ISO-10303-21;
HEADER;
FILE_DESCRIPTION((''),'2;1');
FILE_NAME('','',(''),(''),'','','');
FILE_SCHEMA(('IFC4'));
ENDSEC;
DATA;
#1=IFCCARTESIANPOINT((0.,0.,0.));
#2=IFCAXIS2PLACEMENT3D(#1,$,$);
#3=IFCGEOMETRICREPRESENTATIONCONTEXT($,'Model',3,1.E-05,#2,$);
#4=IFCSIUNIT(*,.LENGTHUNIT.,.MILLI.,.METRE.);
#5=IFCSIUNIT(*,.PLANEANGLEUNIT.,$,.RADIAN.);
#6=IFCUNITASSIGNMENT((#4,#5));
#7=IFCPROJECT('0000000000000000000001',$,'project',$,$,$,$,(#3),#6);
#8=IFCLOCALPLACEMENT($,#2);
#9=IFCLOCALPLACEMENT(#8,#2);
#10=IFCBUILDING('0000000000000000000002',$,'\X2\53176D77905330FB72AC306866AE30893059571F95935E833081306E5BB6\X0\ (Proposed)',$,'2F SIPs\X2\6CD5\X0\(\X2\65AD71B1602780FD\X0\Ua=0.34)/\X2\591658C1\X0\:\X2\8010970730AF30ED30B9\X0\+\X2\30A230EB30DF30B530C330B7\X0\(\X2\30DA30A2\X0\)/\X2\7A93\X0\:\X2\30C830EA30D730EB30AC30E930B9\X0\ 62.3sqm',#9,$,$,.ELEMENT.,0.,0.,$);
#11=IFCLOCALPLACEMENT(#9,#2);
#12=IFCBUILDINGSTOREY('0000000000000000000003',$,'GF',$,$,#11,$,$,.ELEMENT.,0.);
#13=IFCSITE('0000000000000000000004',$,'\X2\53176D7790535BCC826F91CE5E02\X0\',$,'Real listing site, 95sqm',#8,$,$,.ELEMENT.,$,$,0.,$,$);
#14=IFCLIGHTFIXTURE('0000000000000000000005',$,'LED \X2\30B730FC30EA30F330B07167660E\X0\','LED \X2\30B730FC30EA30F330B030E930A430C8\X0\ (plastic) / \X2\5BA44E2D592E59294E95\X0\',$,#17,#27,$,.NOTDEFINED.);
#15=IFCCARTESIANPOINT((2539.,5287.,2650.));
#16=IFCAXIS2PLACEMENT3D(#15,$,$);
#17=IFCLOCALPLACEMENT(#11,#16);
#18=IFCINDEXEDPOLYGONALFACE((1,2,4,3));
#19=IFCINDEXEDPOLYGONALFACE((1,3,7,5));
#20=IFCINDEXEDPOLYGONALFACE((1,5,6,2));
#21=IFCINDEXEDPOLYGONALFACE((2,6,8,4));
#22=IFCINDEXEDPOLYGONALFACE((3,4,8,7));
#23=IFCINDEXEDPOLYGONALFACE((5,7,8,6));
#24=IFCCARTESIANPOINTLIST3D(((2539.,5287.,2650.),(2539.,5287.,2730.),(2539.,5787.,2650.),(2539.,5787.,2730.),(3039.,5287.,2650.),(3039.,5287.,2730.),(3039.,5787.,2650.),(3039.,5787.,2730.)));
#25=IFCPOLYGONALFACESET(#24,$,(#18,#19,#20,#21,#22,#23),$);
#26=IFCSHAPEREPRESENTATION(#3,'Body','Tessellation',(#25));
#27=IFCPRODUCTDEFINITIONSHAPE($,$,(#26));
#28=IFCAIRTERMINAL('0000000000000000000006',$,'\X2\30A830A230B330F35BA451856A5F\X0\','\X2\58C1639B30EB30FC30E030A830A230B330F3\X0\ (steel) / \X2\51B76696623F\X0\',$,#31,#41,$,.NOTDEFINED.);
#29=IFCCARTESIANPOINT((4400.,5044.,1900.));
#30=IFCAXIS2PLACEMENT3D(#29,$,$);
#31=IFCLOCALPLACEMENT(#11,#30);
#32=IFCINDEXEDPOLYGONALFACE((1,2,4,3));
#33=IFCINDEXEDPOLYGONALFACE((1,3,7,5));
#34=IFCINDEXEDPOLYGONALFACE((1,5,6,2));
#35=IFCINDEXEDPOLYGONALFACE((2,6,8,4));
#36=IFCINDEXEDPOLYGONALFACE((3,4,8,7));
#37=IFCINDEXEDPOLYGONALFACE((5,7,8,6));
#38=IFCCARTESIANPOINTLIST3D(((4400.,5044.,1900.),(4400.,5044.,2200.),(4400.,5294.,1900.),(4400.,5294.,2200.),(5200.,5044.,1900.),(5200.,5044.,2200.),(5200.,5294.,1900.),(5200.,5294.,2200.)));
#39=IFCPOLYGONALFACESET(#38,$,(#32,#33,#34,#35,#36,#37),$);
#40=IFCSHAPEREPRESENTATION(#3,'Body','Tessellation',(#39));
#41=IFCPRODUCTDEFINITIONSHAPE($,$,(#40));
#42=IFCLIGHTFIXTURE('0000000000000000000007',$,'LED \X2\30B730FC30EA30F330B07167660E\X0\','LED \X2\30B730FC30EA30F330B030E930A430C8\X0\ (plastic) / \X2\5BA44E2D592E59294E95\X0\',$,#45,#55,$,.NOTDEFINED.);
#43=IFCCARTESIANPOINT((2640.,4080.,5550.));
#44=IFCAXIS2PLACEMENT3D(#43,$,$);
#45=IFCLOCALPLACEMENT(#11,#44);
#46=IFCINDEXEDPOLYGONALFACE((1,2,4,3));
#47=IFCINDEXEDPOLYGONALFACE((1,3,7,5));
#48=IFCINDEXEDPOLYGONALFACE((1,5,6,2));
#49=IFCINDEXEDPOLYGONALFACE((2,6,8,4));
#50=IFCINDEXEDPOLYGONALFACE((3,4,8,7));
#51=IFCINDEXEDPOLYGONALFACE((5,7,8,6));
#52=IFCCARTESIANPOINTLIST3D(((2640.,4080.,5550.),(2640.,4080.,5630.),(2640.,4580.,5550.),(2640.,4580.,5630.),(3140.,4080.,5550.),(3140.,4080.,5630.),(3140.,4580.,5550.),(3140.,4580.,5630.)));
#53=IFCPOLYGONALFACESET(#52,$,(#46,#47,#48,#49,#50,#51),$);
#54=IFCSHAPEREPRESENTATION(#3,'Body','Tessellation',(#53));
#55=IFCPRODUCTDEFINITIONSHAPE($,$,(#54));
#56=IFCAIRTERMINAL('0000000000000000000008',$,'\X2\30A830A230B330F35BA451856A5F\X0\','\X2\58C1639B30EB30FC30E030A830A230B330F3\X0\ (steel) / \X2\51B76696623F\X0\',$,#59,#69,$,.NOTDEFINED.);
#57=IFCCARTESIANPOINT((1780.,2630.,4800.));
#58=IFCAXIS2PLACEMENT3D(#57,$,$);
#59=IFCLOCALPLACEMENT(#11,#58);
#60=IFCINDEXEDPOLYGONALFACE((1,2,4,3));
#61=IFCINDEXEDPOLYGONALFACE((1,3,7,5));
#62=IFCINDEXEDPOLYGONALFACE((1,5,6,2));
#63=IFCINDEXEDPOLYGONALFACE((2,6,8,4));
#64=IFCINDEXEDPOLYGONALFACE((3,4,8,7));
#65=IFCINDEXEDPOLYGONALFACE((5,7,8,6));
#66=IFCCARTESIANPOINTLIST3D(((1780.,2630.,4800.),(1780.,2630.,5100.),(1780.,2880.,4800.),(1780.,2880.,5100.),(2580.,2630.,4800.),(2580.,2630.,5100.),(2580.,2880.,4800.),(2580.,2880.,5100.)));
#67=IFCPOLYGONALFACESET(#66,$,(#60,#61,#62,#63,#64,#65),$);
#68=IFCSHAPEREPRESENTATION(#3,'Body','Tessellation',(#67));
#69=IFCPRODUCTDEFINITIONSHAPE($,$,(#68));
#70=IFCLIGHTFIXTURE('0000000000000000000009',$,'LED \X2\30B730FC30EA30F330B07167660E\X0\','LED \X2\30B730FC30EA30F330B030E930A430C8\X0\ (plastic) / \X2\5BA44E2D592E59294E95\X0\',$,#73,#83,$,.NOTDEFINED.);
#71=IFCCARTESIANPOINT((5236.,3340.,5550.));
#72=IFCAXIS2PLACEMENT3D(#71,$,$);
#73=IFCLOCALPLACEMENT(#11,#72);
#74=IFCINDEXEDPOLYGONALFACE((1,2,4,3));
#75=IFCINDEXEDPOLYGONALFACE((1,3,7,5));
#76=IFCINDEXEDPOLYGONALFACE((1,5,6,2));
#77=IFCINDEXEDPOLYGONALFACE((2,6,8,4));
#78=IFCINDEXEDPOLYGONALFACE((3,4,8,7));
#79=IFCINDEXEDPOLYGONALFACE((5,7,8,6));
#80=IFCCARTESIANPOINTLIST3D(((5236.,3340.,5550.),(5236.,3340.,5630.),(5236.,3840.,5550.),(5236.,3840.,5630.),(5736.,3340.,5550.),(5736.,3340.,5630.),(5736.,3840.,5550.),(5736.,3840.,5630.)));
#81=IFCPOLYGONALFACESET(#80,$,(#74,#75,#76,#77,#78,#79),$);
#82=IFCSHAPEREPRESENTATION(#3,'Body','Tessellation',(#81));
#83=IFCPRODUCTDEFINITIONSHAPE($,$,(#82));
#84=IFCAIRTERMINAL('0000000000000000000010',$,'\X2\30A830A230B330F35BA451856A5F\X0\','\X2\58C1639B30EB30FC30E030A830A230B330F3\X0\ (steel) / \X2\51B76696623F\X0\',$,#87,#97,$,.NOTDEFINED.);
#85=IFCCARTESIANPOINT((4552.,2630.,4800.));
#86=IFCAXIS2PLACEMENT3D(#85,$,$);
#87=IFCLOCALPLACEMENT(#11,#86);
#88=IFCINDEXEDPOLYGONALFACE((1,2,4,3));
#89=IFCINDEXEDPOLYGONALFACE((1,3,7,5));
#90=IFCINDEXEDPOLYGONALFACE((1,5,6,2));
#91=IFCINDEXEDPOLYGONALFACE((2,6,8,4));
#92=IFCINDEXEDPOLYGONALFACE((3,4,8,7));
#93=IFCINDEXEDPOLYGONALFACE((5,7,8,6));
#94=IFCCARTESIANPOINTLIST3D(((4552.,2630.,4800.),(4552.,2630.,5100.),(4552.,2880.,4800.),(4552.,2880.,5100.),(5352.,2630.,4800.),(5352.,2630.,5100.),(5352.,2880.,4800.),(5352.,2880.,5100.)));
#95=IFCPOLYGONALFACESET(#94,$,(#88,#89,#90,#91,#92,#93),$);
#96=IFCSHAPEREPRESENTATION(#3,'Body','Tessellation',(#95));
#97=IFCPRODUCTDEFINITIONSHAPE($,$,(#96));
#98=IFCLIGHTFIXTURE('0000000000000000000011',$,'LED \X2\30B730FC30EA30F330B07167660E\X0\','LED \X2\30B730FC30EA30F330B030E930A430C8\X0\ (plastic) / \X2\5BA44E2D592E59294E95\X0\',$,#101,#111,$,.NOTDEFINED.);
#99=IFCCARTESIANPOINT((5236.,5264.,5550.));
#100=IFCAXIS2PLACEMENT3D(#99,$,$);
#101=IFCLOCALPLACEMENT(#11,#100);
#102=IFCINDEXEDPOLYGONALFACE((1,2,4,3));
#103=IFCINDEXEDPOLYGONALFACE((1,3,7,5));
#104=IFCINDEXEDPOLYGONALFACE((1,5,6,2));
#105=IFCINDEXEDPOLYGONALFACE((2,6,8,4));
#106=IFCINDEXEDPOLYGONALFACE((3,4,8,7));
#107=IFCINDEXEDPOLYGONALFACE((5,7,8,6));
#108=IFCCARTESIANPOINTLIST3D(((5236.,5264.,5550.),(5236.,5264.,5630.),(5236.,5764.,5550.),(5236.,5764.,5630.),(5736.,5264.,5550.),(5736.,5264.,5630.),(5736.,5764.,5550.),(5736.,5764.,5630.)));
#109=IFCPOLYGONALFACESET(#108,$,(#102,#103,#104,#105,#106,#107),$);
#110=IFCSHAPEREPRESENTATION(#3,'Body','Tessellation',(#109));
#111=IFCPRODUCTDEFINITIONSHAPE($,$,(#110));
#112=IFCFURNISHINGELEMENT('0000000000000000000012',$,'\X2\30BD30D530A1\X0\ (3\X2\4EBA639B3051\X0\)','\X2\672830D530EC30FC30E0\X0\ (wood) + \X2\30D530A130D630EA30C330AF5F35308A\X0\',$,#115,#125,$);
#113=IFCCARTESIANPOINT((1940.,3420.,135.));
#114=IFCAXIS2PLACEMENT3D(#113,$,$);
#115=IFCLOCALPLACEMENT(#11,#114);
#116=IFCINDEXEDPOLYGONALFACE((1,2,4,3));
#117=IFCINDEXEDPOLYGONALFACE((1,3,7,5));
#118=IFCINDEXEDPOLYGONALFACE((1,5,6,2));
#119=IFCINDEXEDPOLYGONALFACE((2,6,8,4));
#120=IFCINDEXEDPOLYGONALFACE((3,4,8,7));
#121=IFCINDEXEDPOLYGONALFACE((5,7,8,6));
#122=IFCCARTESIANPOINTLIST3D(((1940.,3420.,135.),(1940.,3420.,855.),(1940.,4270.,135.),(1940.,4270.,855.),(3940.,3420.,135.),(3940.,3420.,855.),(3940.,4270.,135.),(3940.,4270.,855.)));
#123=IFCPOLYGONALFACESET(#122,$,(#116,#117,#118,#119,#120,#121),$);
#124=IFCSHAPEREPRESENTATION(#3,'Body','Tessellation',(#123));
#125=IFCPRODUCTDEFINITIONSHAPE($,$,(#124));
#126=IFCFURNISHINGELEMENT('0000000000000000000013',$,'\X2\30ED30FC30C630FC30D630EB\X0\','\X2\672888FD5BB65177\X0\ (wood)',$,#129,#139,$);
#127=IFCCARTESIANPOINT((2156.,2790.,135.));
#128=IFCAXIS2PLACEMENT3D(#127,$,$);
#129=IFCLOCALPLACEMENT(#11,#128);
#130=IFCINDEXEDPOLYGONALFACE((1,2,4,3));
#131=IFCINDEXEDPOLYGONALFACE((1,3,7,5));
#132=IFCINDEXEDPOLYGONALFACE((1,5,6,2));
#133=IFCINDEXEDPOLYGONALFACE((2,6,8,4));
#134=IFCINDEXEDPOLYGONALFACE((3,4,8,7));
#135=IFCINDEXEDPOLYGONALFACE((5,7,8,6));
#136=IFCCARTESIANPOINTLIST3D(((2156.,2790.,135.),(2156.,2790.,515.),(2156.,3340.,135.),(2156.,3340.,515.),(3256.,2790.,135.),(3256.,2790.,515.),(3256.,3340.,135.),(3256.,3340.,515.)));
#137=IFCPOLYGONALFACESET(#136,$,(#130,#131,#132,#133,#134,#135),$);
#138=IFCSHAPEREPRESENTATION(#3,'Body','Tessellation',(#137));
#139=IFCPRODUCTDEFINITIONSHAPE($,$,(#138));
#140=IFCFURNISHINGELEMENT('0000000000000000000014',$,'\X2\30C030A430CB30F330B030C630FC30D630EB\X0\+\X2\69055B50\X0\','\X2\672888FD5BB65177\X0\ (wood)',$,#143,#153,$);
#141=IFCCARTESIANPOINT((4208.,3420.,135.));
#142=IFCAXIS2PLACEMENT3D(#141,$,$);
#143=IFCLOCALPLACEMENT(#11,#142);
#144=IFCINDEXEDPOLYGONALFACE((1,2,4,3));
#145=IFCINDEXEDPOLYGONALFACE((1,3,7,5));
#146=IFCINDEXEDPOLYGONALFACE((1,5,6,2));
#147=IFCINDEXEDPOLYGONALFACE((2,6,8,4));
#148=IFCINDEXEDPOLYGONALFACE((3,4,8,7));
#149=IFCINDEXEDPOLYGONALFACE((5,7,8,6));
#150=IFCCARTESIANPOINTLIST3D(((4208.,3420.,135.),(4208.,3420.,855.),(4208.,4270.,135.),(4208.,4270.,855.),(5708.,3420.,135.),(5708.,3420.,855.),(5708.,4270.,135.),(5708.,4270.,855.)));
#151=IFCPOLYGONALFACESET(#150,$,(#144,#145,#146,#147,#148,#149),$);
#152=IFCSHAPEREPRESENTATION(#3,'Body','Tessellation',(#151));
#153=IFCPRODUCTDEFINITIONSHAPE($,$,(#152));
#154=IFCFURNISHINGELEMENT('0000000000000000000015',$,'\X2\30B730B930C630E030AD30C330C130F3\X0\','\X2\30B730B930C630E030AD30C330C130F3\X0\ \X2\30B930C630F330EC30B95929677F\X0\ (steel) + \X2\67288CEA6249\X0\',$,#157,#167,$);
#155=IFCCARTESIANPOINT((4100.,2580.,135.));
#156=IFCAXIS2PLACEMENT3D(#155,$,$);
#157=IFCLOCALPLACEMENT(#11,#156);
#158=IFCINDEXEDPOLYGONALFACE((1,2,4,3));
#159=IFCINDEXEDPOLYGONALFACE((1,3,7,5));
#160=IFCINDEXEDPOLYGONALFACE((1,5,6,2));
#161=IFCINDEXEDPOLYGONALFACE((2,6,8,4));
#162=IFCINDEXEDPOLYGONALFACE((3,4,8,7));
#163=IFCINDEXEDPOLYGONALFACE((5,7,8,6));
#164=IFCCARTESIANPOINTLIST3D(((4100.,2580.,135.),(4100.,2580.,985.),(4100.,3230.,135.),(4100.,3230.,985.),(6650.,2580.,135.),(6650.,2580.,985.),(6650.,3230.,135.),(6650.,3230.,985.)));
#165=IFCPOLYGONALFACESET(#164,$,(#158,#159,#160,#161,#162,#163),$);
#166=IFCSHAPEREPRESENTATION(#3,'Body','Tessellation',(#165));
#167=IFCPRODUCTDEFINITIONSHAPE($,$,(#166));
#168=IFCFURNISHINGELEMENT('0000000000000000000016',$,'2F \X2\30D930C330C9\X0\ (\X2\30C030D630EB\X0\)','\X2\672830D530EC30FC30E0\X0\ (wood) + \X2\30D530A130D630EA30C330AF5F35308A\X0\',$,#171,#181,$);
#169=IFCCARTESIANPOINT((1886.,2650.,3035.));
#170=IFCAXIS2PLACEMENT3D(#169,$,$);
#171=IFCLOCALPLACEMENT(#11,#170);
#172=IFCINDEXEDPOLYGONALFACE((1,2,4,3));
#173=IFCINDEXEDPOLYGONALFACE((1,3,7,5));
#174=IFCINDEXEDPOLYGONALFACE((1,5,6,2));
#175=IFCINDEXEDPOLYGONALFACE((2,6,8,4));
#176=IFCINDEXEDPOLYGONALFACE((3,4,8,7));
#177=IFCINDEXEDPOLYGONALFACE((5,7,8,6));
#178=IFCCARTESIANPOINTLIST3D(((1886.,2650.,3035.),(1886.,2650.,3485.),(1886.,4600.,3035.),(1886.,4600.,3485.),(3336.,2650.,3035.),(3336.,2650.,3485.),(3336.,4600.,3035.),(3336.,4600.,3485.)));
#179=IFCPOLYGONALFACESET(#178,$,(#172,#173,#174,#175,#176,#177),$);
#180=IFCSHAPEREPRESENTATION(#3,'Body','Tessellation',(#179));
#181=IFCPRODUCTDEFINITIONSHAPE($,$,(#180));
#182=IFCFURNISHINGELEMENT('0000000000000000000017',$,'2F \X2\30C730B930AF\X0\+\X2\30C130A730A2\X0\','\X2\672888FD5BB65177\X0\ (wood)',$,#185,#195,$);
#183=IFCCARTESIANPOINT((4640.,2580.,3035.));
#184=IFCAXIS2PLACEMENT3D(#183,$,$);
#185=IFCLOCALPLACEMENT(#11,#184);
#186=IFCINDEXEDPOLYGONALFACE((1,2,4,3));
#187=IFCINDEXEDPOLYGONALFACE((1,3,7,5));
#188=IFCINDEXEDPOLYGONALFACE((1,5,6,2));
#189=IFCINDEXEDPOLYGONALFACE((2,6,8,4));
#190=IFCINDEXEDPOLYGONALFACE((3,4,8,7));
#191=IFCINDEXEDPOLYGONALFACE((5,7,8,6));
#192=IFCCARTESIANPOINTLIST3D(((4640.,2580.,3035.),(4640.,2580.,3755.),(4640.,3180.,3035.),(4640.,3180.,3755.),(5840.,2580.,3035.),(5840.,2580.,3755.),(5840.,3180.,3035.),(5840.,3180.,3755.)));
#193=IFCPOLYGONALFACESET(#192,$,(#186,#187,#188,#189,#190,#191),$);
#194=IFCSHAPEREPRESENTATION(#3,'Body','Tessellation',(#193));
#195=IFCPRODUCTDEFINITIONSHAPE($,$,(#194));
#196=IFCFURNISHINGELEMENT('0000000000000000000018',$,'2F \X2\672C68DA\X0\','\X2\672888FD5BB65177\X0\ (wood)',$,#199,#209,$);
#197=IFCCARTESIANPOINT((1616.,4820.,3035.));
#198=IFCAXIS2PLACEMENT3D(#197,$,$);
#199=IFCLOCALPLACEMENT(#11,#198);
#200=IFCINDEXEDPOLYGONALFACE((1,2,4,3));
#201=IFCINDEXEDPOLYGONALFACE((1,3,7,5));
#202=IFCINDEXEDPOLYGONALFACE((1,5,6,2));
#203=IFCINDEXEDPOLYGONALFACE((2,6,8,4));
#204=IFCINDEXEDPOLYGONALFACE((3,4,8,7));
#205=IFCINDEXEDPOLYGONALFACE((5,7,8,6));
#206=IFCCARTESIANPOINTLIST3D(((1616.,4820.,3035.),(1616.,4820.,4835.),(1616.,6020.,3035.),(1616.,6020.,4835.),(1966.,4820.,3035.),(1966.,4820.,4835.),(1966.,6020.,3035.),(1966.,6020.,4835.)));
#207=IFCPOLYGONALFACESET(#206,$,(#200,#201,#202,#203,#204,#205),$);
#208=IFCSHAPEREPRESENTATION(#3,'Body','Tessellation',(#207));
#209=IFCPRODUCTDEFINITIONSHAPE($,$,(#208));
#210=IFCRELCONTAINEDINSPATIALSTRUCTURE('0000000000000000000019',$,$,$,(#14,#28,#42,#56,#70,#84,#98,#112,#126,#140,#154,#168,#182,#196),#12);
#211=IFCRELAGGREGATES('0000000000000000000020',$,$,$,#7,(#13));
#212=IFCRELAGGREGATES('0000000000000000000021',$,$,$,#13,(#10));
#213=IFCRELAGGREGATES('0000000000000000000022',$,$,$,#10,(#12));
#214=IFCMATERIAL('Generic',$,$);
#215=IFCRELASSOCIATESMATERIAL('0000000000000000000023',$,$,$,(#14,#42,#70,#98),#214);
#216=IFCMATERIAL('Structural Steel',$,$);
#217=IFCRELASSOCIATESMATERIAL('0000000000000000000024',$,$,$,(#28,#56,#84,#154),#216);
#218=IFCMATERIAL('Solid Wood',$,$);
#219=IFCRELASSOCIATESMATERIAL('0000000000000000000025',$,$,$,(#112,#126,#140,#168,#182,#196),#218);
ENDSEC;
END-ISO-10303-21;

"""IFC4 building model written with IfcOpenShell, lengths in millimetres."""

from ifc_helpers import new_model, si_unit, frame, frame_2d, origin, place, context, project, spatial, rectangle, extrude, material, element, save


model = new_model("IFC4")

# Units and contexts
model_context = context("Model", 3, precision=1e-05, world=origin())
ifc_project = project(units=[si_unit("LENGTHUNIT", "METRE", prefix="MILLI"), si_unit("PLANEANGLEUNIT", "RADIAN")], contexts=[model_context])

# Site, building, storey
site_placement = place(None, origin())
site = spatial("IfcSite", under=ifc_project, at=site_placement, Name="北海道富良野市", ObjectType="Real listing site, 95sqm", CompositionType="ELEMENT", RefElevation=0.0)
building_placement = place(site_placement, origin())
building = spatial("IfcBuilding", under=site, at=building_placement, Name="北海道・犬と暮らす土間広めの家 (Proposed)", ObjectType="2F SIPs法(断熱性能Ua=0.34)/外壁:耐震クロス+アルミサッシ(ペア)/窓:トリプルガラス 62.3sqm", CompositionType="ELEMENT", ElevationOfRefHeight=0.0, ElevationOfTerrain=0.0)
storey_placement = place(building_placement, origin())
storey = spatial("IfcBuildingStorey", under=building, at=storey_placement, Name="GF", CompositionType="ELEMENT", Elevation=0.0)

# Shared definitions
ifc_material_1 = material(Name="Solid Wood")

# Shared definitions
ifc_material_2 = material(Name="Structural Steel")

# Shared definitions
ifc_material_3 = material(Name="Generic")

# Light fixture
light_fixture_1_placement = place(storey_placement, frame((2539.0, 5287.0, 2650.0)))
element("IfcLightFixture", 1, at=light_fixture_1_placement, inside=storey, material=ifc_material_3, Name="LED シーリング照明", Description="LED シーリングライト (plastic) / 室中央天井", PredefinedType="NOTDEFINED", context=model_context, shape_type="SweptSolid", body=[
    extrude(rectangle(XDim=500.0, YDim=500.0, at=frame_2d((250.0, 250.0))), frame((2539.0, 5287.0, 2650.0)), (0.0, 0.0, 1.0), 80.0),
])

# Air terminal
air_terminal_1_placement = place(storey_placement, frame((4400.0, 5044.0, 1900.0)))
element("IfcAirTerminal", 2, at=air_terminal_1_placement, inside=storey, material=ifc_material_2, Name="エアコン室内機", Description="壁掛ルームエアコン (steel) / 冷暖房", PredefinedType="NOTDEFINED", context=model_context, shape_type="SweptSolid", body=[
    extrude(rectangle(XDim=800.0, YDim=250.0, at=frame_2d((400.0, 125.0))), frame((4400.0, 5044.0, 1900.0)), (0.0, 0.0, 1.0), 300.0),
])

# Light fixture
light_fixture_2_placement = place(storey_placement, frame((2640.0, 4080.0, 5550.0)))
element("IfcLightFixture", 3, at=light_fixture_2_placement, inside=storey, material=ifc_material_3, Name="LED シーリング照明", Description="LED シーリングライト (plastic) / 室中央天井", PredefinedType="NOTDEFINED", context=model_context, shape_type="SweptSolid", body=[
    extrude(rectangle(XDim=500.0, YDim=500.0, at=frame_2d((250.0, 250.0))), frame((2640.0, 4080.0, 5550.0)), (0.0, 0.0, 1.0), 80.0),
])

# Air terminal
air_terminal_2_placement = place(storey_placement, frame((1780.0, 2630.0, 4800.0)))
element("IfcAirTerminal", 4, at=air_terminal_2_placement, inside=storey, material=ifc_material_2, Name="エアコン室内機", Description="壁掛ルームエアコン (steel) / 冷暖房", PredefinedType="NOTDEFINED", context=model_context, shape_type="SweptSolid", body=[
    extrude(rectangle(XDim=800.0, YDim=250.0, at=frame_2d((400.0, 125.0))), frame((1780.0, 2630.0, 4800.0)), (0.0, 0.0, 1.0), 300.0),
])

# Light fixture
light_fixture_3_placement = place(storey_placement, frame((5236.0, 3340.0, 5550.0)))
element("IfcLightFixture", 5, at=light_fixture_3_placement, inside=storey, material=ifc_material_3, Name="LED シーリング照明", Description="LED シーリングライト (plastic) / 室中央天井", PredefinedType="NOTDEFINED", context=model_context, shape_type="SweptSolid", body=[
    extrude(rectangle(XDim=500.0, YDim=500.0, at=frame_2d((250.0, 250.0))), frame((5236.0, 3340.0, 5550.0)), (0.0, 0.0, 1.0), 80.0),
])

# Air terminal
air_terminal_3_placement = place(storey_placement, frame((4552.0, 2630.0, 4800.0)))
element("IfcAirTerminal", 6, at=air_terminal_3_placement, inside=storey, material=ifc_material_2, Name="エアコン室内機", Description="壁掛ルームエアコン (steel) / 冷暖房", PredefinedType="NOTDEFINED", context=model_context, shape_type="SweptSolid", body=[
    extrude(rectangle(XDim=800.0, YDim=250.0, at=frame_2d((400.0, 125.0))), frame((4552.0, 2630.0, 4800.0)), (0.0, 0.0, 1.0), 300.0),
])

# Light fixture
light_fixture_4_placement = place(storey_placement, frame((5236.0, 5264.0, 5550.0)))
element("IfcLightFixture", 7, at=light_fixture_4_placement, inside=storey, material=ifc_material_3, Name="LED シーリング照明", Description="LED シーリングライト (plastic) / 室中央天井", PredefinedType="NOTDEFINED", context=model_context, shape_type="SweptSolid", body=[
    extrude(rectangle(XDim=500.0, YDim=500.0, at=frame_2d((250.0, 250.0))), frame((5236.0, 5264.0, 5550.0)), (0.0, 0.0, 1.0), 80.0),
])

# Furnishing elements
furnishing_1_placement = place(storey_placement, frame((1940.0, 3420.0, 135.0)))
element("IfcFurnishingElement", 8, at=furnishing_1_placement, inside=storey, material=ifc_material_1, Name="ソファ (3人掛け)", Description="木フレーム (wood) + ファブリック張り", context=model_context, shape_type="SweptSolid", body=[
    extrude(rectangle(XDim=2000.0, YDim=850.0, at=frame_2d((1000.0, 425.0))), frame((1940.0, 3420.0, 135.0)), (0.0, 0.0, 1.0), 720.0),
])
furnishing_2_placement = place(storey_placement, frame((2156.0, 2790.0, 135.0)))
element("IfcFurnishingElement", 9, at=furnishing_2_placement, inside=storey, material=ifc_material_1, Name="ローテーブル", Description="木製家具 (wood)", context=model_context, shape_type="SweptSolid", body=[
    extrude(rectangle(XDim=1100.0, YDim=550.0, at=frame_2d((550.0, 275.0))), frame((2156.0, 2790.0, 135.0)), (0.0, 0.0, 1.0), 380.0),
])
furnishing_3_placement = place(storey_placement, frame((4208.0, 3420.0, 135.0)))
element("IfcFurnishingElement", 10, at=furnishing_3_placement, inside=storey, material=ifc_material_1, Name="ダイニングテーブル+椅子", Description="木製家具 (wood)", context=model_context, shape_type="SweptSolid", body=[
    extrude(rectangle(XDim=1500.0, YDim=850.0, at=frame_2d((750.0, 425.0))), frame((4208.0, 3420.0, 135.0)), (0.0, 0.0, 1.0), 720.0),
])
furnishing_4_placement = place(storey_placement, frame((4100.0, 2580.0, 135.0)))
element("IfcFurnishingElement", 11, at=furnishing_4_placement, inside=storey, material=ifc_material_2, Name="システムキッチン", Description="システムキッチン ステンレス天板 (steel) + 木質扉", context=model_context, shape_type="SweptSolid", body=[
    extrude(rectangle(XDim=2550.0, YDim=650.0, at=frame_2d((1275.0, 325.0))), frame((4100.0, 2580.0, 135.0)), (0.0, 0.0, 1.0), 850.0),
])
furnishing_5_placement = place(storey_placement, frame((1886.0, 2650.0, 3035.0)))
element("IfcFurnishingElement", 12, at=furnishing_5_placement, inside=storey, material=ifc_material_1, Name="2F ベッド (ダブル)", Description="木フレーム (wood) + ファブリック張り", context=model_context, shape_type="SweptSolid", body=[
    extrude(rectangle(XDim=1450.0, YDim=1950.0, at=frame_2d((725.0, 975.0))), frame((1886.0, 2650.0, 3035.0)), (0.0, 0.0, 1.0), 450.0),
])
furnishing_6_placement = place(storey_placement, frame((4640.0, 2580.0, 3035.0)))
element("IfcFurnishingElement", 13, at=furnishing_6_placement, inside=storey, material=ifc_material_1, Name="2F デスク+チェア", Description="木製家具 (wood)", context=model_context, shape_type="SweptSolid", body=[
    extrude(rectangle(XDim=1200.0, YDim=600.0, at=frame_2d((600.0, 300.0))), frame((4640.0, 2580.0, 3035.0)), (0.0, 0.0, 1.0), 720.0),
])
furnishing_7_placement = place(storey_placement, frame((1616.0, 4820.0, 3035.0)))
element("IfcFurnishingElement", 14, at=furnishing_7_placement, inside=storey, material=ifc_material_1, Name="2F 本棚", Description="木製家具 (wood)", context=model_context, shape_type="SweptSolid", body=[
    extrude(rectangle(XDim=350.0, YDim=1200.0, at=frame_2d((175.0, 600.0))), frame((1616.0, 4820.0, 3035.0)), (0.0, 0.0, 1.0), 1800.0),
])

save(model, "model.ifc")
